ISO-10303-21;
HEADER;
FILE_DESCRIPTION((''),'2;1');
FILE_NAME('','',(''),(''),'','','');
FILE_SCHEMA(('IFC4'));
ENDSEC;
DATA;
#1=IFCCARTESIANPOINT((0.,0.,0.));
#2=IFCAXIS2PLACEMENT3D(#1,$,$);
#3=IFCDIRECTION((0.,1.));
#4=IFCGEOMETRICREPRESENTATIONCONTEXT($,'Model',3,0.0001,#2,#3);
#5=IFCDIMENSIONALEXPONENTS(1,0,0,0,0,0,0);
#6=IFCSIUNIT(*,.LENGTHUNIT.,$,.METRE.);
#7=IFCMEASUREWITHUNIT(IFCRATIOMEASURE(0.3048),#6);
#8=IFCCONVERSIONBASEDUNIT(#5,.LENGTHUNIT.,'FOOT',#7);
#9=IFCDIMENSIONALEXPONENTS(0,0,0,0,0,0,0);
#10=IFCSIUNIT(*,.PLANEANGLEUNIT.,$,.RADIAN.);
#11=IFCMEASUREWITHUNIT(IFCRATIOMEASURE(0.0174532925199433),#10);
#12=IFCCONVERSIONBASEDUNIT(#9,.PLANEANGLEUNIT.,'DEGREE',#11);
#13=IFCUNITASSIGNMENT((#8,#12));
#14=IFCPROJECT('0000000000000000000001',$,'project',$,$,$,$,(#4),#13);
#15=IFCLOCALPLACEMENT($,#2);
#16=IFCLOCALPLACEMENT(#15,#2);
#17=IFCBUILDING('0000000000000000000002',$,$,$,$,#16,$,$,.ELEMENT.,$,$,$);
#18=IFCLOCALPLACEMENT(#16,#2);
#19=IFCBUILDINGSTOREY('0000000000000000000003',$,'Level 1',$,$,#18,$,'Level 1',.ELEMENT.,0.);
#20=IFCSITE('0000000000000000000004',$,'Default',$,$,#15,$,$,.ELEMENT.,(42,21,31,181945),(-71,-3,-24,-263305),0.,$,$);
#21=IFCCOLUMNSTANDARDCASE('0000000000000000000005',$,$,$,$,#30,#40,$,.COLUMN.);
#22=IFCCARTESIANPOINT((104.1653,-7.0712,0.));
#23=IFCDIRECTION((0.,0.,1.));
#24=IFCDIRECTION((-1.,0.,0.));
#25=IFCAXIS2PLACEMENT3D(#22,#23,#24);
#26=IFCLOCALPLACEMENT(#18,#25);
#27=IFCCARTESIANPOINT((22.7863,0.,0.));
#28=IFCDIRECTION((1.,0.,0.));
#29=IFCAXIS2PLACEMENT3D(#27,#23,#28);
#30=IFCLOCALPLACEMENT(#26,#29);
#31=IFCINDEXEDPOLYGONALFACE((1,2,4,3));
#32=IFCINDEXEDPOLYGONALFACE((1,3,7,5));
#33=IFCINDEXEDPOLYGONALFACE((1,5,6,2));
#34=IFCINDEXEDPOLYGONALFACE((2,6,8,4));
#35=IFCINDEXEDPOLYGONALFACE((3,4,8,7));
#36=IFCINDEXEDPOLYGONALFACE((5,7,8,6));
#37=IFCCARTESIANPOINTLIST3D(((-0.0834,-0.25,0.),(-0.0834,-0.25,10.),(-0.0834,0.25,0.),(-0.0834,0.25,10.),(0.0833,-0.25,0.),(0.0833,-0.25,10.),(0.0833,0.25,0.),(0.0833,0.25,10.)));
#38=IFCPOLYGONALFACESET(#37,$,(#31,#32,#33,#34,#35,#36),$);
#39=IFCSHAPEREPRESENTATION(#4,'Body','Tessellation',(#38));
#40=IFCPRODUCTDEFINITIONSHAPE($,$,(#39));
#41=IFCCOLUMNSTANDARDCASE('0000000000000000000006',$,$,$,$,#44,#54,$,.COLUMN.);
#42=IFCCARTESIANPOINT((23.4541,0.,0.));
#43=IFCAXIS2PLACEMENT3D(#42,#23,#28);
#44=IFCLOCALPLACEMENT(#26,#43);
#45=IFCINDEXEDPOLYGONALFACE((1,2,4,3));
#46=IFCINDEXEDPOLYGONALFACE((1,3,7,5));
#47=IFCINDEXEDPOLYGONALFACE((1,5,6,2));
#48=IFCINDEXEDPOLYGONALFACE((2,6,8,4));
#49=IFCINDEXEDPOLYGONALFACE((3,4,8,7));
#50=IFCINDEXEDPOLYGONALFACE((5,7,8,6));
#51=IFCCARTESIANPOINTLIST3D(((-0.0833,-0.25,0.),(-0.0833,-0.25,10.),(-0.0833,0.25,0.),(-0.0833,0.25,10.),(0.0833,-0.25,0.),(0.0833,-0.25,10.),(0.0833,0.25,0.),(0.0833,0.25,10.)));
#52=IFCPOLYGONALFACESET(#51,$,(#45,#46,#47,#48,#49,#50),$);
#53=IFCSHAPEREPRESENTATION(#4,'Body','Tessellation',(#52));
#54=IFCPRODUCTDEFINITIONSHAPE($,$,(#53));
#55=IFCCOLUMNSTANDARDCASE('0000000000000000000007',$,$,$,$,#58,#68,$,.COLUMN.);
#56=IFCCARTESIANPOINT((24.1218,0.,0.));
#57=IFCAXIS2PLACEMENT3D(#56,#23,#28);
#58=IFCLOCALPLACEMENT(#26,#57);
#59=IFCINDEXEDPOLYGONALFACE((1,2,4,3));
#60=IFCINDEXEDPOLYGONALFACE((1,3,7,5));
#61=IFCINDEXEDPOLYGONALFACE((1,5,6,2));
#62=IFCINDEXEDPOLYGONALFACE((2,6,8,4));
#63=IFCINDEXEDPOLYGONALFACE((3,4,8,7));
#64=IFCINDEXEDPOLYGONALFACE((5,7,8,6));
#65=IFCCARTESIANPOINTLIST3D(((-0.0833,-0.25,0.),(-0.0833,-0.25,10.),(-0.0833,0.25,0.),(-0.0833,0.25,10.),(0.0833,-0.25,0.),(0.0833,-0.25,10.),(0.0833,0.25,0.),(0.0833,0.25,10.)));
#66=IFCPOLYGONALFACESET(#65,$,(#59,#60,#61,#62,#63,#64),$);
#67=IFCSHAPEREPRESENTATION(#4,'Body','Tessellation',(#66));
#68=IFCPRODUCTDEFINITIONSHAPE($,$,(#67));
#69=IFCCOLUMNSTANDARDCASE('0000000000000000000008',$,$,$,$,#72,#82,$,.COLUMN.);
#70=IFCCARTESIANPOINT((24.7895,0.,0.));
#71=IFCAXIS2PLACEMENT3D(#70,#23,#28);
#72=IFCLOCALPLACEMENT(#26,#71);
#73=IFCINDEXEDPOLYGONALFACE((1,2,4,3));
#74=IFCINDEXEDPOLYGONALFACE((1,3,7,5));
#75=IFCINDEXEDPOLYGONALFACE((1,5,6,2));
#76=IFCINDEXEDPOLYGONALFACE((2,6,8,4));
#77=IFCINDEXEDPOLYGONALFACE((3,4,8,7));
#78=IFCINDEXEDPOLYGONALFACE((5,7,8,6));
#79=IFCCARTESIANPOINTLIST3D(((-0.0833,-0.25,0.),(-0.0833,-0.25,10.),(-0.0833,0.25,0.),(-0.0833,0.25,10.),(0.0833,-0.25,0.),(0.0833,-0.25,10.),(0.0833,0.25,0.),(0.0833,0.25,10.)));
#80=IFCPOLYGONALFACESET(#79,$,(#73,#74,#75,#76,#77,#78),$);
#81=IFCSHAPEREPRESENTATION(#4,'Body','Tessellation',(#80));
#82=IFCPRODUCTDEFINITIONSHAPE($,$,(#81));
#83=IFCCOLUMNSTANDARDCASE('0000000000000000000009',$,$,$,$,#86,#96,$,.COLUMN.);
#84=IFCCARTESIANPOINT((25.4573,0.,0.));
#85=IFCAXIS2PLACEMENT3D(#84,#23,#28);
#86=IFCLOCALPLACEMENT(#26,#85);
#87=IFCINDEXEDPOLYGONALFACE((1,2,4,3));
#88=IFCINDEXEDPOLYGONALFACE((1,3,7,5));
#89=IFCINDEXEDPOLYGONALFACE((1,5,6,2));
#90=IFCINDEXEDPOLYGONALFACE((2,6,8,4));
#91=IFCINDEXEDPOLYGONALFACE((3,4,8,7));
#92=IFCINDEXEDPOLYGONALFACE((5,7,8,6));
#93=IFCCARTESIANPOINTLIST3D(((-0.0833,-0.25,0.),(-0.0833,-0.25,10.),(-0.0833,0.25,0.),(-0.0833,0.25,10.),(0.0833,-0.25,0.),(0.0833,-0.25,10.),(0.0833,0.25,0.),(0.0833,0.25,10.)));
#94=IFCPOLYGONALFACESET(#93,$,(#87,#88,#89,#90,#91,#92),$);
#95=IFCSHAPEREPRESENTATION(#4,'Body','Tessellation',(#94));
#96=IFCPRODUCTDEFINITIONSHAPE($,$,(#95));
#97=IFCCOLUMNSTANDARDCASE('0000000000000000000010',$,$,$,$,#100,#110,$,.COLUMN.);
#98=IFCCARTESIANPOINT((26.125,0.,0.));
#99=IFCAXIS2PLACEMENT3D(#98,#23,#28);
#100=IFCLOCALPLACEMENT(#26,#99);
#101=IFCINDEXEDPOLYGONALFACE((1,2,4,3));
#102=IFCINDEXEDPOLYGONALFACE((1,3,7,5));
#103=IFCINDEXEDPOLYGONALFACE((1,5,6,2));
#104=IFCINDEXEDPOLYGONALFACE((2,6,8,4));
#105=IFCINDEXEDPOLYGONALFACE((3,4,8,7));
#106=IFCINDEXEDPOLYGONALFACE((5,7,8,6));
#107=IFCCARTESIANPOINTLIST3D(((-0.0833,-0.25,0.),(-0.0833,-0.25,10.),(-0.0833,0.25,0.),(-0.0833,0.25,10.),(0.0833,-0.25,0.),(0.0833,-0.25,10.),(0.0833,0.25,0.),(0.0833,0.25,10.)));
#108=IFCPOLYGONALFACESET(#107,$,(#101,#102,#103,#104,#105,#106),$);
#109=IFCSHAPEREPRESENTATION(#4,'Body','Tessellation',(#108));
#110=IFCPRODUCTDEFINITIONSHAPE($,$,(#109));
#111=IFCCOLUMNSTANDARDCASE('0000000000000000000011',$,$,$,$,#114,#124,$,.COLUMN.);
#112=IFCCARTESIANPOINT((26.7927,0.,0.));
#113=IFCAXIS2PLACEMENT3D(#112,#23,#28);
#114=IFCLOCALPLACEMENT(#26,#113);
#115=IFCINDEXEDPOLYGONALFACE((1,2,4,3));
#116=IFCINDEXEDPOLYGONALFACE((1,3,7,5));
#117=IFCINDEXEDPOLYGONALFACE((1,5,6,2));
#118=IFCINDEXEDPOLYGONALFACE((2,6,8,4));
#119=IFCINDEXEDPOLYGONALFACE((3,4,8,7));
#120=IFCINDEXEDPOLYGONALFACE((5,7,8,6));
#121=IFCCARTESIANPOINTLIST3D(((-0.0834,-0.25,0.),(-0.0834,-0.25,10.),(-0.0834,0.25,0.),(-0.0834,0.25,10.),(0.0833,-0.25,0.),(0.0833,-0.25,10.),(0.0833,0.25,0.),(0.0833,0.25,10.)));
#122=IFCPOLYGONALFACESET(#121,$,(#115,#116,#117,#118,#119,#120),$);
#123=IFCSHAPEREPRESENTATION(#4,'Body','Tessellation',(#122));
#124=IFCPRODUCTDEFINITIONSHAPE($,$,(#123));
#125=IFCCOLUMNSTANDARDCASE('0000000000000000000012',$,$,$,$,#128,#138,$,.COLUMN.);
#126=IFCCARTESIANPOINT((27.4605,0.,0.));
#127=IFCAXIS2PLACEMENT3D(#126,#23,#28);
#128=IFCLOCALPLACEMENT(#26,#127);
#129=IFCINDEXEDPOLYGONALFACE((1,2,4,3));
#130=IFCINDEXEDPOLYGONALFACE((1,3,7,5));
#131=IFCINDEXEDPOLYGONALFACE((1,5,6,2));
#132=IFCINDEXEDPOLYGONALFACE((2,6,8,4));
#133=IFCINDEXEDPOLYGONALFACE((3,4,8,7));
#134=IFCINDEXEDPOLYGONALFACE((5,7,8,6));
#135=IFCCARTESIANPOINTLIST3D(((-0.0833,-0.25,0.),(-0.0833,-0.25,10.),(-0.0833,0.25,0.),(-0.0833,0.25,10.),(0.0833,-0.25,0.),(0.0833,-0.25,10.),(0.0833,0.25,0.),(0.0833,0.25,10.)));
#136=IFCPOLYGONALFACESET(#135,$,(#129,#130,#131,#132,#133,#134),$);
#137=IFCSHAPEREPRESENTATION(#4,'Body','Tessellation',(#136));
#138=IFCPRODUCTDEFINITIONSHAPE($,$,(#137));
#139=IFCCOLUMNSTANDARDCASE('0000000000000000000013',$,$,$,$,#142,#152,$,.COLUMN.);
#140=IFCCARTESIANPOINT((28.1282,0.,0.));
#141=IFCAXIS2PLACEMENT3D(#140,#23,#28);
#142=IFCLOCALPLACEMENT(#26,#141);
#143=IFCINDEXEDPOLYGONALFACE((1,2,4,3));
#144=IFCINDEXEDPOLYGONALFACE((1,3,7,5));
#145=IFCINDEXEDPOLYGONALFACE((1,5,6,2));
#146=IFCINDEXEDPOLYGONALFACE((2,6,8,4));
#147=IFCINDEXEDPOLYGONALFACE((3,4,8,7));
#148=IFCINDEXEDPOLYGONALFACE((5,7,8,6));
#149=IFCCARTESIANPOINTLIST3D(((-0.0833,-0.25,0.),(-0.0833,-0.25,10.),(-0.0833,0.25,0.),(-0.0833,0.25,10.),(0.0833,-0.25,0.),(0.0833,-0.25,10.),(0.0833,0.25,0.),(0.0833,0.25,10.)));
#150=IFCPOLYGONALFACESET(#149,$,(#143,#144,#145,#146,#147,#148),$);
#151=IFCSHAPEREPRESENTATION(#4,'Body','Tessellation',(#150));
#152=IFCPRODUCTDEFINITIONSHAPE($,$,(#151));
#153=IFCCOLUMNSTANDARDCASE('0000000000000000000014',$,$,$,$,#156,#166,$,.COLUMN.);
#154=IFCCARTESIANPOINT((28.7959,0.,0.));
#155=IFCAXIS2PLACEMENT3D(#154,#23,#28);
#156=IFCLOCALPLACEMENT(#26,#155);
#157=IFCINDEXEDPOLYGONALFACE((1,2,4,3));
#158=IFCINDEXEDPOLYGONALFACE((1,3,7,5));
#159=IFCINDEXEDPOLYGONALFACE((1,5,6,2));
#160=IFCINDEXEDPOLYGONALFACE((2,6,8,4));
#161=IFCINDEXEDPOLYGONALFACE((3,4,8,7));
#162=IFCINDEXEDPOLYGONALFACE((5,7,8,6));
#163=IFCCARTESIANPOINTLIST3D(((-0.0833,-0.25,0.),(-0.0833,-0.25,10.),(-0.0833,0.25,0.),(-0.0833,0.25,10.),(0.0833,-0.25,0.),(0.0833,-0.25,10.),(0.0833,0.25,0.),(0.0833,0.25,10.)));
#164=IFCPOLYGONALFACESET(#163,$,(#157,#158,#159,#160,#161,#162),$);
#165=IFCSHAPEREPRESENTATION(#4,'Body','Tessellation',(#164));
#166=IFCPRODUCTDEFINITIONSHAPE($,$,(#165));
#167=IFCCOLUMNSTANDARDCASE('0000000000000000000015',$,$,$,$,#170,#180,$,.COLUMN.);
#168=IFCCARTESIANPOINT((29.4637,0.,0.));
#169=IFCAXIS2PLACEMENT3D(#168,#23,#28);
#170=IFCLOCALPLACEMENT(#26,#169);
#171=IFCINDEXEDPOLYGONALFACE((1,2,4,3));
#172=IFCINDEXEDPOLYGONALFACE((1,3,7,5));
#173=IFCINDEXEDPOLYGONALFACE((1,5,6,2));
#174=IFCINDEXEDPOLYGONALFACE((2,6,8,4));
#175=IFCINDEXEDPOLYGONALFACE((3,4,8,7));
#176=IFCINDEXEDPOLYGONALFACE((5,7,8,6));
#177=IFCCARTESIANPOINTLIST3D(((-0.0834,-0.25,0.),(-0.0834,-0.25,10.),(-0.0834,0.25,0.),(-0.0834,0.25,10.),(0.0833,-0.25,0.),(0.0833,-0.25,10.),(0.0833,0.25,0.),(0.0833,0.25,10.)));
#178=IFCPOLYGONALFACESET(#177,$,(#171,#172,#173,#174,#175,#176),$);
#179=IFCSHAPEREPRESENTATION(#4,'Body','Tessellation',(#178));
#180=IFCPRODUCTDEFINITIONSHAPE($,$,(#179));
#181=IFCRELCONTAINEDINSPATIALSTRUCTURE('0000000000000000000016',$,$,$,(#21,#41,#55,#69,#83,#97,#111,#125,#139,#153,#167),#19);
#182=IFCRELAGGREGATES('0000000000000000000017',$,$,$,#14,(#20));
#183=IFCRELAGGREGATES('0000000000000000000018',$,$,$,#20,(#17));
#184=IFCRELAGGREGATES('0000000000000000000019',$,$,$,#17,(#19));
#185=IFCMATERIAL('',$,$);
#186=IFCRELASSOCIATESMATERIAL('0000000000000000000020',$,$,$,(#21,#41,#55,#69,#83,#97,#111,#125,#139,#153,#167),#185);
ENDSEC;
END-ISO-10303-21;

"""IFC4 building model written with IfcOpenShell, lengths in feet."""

from ifc_helpers import new_model, entity, si_unit, converted_unit, direction, frame, origin, place, context, project, spatial, rectangle, extrude, material, element, save


model = new_model("IFC4")

# Units and contexts
model_context = context("Model", 3, precision=0.0001, world=origin(), true_north=direction((0.0, 1.0)))
ifc_project = project(units=[converted_unit("LENGTHUNIT", "FOOT", entity("IfcRatioMeasure", 0.3048), si_unit("LENGTHUNIT", "METRE"), dimensions=[1, 0, 0, 0, 0, 0, 0]), converted_unit("PLANEANGLEUNIT", "DEGREE", entity("IfcRatioMeasure", 0.0174532925199433), si_unit("PLANEANGLEUNIT", "RADIAN"), dimensions=[0, 0, 0, 0, 0, 0, 0])], contexts=[model_context])

# Site, building, storey
site_placement = place(None, origin())
site = spatial("IfcSite", under=ifc_project, at=site_placement, Name="Default", CompositionType="ELEMENT", RefLatitude=(42, 21, 31, 181945), RefLongitude=(-71, -3, -24, -263305), RefElevation=0.0)
building_placement = place(site_placement, origin())
building = spatial("IfcBuilding", under=site, at=building_placement, CompositionType="ELEMENT")
storey_placement = place(building_placement, origin())
storey = spatial("IfcBuildingStorey", under=building, at=storey_placement, Name="Level 1", LongName="Level 1", CompositionType="ELEMENT", Elevation=0.0)

# Columns
ifc_material = material(Name="")
placement = place(storey_placement, frame((104.1653, -7.0712, 0.0), z_axis=(0.0, 0.0, 1.0), x_axis=(-1.0, 0.0, 0.0)))
for number, where, z_axis, x_axis in (
    (1, (22.7863, 0.0, 0.0), (0.0, 0.0, 1.0), (1.0, 0.0, 0.0)),
    (2, (23.4541, 0.0, 0.0), (0.0, 0.0, 1.0), (1.0, 0.0, 0.0)),
    (3, (24.1218, 0.0, 0.0), (0.0, 0.0, 1.0), (1.0, 0.0, 0.0)),
    (4, (24.7895, 0.0, 0.0), (0.0, 0.0, 1.0), (1.0, 0.0, 0.0)),
    (5, (25.4573, 0.0, 0.0), (0.0, 0.0, 1.0), (1.0, 0.0, 0.0)),
    (6, (26.125, 0.0, 0.0), (0.0, 0.0, 1.0), (1.0, 0.0, 0.0)),
    (7, (26.7927, 0.0, 0.0), (0.0, 0.0, 1.0), (1.0, 0.0, 0.0)),
    (8, (27.4605, 0.0, 0.0), (0.0, 0.0, 1.0), (1.0, 0.0, 0.0)),
    (9, (28.1282, 0.0, 0.0), (0.0, 0.0, 1.0), (1.0, 0.0, 0.0)),
    (10, (28.7959, 0.0, 0.0), (0.0, 0.0, 1.0), (1.0, 0.0, 0.0)),
    (11, (29.4637, 0.0, 0.0), (0.0, 0.0, 1.0), (1.0, 0.0, 0.0)),
):
    element("IfcColumnStandardCase", number, at=place(placement, frame(where, z_axis=z_axis, x_axis=x_axis)), inside=storey, material=ifc_material, PredefinedType="COLUMN", context=model_context, shape_type="SweptSolid", body=[
        extrude(rectangle(XDim=0.1667, YDim=0.5), origin(), (0.0, 0.0, 1.0), 10.0),
    ])

save(model, "model.ifc")
